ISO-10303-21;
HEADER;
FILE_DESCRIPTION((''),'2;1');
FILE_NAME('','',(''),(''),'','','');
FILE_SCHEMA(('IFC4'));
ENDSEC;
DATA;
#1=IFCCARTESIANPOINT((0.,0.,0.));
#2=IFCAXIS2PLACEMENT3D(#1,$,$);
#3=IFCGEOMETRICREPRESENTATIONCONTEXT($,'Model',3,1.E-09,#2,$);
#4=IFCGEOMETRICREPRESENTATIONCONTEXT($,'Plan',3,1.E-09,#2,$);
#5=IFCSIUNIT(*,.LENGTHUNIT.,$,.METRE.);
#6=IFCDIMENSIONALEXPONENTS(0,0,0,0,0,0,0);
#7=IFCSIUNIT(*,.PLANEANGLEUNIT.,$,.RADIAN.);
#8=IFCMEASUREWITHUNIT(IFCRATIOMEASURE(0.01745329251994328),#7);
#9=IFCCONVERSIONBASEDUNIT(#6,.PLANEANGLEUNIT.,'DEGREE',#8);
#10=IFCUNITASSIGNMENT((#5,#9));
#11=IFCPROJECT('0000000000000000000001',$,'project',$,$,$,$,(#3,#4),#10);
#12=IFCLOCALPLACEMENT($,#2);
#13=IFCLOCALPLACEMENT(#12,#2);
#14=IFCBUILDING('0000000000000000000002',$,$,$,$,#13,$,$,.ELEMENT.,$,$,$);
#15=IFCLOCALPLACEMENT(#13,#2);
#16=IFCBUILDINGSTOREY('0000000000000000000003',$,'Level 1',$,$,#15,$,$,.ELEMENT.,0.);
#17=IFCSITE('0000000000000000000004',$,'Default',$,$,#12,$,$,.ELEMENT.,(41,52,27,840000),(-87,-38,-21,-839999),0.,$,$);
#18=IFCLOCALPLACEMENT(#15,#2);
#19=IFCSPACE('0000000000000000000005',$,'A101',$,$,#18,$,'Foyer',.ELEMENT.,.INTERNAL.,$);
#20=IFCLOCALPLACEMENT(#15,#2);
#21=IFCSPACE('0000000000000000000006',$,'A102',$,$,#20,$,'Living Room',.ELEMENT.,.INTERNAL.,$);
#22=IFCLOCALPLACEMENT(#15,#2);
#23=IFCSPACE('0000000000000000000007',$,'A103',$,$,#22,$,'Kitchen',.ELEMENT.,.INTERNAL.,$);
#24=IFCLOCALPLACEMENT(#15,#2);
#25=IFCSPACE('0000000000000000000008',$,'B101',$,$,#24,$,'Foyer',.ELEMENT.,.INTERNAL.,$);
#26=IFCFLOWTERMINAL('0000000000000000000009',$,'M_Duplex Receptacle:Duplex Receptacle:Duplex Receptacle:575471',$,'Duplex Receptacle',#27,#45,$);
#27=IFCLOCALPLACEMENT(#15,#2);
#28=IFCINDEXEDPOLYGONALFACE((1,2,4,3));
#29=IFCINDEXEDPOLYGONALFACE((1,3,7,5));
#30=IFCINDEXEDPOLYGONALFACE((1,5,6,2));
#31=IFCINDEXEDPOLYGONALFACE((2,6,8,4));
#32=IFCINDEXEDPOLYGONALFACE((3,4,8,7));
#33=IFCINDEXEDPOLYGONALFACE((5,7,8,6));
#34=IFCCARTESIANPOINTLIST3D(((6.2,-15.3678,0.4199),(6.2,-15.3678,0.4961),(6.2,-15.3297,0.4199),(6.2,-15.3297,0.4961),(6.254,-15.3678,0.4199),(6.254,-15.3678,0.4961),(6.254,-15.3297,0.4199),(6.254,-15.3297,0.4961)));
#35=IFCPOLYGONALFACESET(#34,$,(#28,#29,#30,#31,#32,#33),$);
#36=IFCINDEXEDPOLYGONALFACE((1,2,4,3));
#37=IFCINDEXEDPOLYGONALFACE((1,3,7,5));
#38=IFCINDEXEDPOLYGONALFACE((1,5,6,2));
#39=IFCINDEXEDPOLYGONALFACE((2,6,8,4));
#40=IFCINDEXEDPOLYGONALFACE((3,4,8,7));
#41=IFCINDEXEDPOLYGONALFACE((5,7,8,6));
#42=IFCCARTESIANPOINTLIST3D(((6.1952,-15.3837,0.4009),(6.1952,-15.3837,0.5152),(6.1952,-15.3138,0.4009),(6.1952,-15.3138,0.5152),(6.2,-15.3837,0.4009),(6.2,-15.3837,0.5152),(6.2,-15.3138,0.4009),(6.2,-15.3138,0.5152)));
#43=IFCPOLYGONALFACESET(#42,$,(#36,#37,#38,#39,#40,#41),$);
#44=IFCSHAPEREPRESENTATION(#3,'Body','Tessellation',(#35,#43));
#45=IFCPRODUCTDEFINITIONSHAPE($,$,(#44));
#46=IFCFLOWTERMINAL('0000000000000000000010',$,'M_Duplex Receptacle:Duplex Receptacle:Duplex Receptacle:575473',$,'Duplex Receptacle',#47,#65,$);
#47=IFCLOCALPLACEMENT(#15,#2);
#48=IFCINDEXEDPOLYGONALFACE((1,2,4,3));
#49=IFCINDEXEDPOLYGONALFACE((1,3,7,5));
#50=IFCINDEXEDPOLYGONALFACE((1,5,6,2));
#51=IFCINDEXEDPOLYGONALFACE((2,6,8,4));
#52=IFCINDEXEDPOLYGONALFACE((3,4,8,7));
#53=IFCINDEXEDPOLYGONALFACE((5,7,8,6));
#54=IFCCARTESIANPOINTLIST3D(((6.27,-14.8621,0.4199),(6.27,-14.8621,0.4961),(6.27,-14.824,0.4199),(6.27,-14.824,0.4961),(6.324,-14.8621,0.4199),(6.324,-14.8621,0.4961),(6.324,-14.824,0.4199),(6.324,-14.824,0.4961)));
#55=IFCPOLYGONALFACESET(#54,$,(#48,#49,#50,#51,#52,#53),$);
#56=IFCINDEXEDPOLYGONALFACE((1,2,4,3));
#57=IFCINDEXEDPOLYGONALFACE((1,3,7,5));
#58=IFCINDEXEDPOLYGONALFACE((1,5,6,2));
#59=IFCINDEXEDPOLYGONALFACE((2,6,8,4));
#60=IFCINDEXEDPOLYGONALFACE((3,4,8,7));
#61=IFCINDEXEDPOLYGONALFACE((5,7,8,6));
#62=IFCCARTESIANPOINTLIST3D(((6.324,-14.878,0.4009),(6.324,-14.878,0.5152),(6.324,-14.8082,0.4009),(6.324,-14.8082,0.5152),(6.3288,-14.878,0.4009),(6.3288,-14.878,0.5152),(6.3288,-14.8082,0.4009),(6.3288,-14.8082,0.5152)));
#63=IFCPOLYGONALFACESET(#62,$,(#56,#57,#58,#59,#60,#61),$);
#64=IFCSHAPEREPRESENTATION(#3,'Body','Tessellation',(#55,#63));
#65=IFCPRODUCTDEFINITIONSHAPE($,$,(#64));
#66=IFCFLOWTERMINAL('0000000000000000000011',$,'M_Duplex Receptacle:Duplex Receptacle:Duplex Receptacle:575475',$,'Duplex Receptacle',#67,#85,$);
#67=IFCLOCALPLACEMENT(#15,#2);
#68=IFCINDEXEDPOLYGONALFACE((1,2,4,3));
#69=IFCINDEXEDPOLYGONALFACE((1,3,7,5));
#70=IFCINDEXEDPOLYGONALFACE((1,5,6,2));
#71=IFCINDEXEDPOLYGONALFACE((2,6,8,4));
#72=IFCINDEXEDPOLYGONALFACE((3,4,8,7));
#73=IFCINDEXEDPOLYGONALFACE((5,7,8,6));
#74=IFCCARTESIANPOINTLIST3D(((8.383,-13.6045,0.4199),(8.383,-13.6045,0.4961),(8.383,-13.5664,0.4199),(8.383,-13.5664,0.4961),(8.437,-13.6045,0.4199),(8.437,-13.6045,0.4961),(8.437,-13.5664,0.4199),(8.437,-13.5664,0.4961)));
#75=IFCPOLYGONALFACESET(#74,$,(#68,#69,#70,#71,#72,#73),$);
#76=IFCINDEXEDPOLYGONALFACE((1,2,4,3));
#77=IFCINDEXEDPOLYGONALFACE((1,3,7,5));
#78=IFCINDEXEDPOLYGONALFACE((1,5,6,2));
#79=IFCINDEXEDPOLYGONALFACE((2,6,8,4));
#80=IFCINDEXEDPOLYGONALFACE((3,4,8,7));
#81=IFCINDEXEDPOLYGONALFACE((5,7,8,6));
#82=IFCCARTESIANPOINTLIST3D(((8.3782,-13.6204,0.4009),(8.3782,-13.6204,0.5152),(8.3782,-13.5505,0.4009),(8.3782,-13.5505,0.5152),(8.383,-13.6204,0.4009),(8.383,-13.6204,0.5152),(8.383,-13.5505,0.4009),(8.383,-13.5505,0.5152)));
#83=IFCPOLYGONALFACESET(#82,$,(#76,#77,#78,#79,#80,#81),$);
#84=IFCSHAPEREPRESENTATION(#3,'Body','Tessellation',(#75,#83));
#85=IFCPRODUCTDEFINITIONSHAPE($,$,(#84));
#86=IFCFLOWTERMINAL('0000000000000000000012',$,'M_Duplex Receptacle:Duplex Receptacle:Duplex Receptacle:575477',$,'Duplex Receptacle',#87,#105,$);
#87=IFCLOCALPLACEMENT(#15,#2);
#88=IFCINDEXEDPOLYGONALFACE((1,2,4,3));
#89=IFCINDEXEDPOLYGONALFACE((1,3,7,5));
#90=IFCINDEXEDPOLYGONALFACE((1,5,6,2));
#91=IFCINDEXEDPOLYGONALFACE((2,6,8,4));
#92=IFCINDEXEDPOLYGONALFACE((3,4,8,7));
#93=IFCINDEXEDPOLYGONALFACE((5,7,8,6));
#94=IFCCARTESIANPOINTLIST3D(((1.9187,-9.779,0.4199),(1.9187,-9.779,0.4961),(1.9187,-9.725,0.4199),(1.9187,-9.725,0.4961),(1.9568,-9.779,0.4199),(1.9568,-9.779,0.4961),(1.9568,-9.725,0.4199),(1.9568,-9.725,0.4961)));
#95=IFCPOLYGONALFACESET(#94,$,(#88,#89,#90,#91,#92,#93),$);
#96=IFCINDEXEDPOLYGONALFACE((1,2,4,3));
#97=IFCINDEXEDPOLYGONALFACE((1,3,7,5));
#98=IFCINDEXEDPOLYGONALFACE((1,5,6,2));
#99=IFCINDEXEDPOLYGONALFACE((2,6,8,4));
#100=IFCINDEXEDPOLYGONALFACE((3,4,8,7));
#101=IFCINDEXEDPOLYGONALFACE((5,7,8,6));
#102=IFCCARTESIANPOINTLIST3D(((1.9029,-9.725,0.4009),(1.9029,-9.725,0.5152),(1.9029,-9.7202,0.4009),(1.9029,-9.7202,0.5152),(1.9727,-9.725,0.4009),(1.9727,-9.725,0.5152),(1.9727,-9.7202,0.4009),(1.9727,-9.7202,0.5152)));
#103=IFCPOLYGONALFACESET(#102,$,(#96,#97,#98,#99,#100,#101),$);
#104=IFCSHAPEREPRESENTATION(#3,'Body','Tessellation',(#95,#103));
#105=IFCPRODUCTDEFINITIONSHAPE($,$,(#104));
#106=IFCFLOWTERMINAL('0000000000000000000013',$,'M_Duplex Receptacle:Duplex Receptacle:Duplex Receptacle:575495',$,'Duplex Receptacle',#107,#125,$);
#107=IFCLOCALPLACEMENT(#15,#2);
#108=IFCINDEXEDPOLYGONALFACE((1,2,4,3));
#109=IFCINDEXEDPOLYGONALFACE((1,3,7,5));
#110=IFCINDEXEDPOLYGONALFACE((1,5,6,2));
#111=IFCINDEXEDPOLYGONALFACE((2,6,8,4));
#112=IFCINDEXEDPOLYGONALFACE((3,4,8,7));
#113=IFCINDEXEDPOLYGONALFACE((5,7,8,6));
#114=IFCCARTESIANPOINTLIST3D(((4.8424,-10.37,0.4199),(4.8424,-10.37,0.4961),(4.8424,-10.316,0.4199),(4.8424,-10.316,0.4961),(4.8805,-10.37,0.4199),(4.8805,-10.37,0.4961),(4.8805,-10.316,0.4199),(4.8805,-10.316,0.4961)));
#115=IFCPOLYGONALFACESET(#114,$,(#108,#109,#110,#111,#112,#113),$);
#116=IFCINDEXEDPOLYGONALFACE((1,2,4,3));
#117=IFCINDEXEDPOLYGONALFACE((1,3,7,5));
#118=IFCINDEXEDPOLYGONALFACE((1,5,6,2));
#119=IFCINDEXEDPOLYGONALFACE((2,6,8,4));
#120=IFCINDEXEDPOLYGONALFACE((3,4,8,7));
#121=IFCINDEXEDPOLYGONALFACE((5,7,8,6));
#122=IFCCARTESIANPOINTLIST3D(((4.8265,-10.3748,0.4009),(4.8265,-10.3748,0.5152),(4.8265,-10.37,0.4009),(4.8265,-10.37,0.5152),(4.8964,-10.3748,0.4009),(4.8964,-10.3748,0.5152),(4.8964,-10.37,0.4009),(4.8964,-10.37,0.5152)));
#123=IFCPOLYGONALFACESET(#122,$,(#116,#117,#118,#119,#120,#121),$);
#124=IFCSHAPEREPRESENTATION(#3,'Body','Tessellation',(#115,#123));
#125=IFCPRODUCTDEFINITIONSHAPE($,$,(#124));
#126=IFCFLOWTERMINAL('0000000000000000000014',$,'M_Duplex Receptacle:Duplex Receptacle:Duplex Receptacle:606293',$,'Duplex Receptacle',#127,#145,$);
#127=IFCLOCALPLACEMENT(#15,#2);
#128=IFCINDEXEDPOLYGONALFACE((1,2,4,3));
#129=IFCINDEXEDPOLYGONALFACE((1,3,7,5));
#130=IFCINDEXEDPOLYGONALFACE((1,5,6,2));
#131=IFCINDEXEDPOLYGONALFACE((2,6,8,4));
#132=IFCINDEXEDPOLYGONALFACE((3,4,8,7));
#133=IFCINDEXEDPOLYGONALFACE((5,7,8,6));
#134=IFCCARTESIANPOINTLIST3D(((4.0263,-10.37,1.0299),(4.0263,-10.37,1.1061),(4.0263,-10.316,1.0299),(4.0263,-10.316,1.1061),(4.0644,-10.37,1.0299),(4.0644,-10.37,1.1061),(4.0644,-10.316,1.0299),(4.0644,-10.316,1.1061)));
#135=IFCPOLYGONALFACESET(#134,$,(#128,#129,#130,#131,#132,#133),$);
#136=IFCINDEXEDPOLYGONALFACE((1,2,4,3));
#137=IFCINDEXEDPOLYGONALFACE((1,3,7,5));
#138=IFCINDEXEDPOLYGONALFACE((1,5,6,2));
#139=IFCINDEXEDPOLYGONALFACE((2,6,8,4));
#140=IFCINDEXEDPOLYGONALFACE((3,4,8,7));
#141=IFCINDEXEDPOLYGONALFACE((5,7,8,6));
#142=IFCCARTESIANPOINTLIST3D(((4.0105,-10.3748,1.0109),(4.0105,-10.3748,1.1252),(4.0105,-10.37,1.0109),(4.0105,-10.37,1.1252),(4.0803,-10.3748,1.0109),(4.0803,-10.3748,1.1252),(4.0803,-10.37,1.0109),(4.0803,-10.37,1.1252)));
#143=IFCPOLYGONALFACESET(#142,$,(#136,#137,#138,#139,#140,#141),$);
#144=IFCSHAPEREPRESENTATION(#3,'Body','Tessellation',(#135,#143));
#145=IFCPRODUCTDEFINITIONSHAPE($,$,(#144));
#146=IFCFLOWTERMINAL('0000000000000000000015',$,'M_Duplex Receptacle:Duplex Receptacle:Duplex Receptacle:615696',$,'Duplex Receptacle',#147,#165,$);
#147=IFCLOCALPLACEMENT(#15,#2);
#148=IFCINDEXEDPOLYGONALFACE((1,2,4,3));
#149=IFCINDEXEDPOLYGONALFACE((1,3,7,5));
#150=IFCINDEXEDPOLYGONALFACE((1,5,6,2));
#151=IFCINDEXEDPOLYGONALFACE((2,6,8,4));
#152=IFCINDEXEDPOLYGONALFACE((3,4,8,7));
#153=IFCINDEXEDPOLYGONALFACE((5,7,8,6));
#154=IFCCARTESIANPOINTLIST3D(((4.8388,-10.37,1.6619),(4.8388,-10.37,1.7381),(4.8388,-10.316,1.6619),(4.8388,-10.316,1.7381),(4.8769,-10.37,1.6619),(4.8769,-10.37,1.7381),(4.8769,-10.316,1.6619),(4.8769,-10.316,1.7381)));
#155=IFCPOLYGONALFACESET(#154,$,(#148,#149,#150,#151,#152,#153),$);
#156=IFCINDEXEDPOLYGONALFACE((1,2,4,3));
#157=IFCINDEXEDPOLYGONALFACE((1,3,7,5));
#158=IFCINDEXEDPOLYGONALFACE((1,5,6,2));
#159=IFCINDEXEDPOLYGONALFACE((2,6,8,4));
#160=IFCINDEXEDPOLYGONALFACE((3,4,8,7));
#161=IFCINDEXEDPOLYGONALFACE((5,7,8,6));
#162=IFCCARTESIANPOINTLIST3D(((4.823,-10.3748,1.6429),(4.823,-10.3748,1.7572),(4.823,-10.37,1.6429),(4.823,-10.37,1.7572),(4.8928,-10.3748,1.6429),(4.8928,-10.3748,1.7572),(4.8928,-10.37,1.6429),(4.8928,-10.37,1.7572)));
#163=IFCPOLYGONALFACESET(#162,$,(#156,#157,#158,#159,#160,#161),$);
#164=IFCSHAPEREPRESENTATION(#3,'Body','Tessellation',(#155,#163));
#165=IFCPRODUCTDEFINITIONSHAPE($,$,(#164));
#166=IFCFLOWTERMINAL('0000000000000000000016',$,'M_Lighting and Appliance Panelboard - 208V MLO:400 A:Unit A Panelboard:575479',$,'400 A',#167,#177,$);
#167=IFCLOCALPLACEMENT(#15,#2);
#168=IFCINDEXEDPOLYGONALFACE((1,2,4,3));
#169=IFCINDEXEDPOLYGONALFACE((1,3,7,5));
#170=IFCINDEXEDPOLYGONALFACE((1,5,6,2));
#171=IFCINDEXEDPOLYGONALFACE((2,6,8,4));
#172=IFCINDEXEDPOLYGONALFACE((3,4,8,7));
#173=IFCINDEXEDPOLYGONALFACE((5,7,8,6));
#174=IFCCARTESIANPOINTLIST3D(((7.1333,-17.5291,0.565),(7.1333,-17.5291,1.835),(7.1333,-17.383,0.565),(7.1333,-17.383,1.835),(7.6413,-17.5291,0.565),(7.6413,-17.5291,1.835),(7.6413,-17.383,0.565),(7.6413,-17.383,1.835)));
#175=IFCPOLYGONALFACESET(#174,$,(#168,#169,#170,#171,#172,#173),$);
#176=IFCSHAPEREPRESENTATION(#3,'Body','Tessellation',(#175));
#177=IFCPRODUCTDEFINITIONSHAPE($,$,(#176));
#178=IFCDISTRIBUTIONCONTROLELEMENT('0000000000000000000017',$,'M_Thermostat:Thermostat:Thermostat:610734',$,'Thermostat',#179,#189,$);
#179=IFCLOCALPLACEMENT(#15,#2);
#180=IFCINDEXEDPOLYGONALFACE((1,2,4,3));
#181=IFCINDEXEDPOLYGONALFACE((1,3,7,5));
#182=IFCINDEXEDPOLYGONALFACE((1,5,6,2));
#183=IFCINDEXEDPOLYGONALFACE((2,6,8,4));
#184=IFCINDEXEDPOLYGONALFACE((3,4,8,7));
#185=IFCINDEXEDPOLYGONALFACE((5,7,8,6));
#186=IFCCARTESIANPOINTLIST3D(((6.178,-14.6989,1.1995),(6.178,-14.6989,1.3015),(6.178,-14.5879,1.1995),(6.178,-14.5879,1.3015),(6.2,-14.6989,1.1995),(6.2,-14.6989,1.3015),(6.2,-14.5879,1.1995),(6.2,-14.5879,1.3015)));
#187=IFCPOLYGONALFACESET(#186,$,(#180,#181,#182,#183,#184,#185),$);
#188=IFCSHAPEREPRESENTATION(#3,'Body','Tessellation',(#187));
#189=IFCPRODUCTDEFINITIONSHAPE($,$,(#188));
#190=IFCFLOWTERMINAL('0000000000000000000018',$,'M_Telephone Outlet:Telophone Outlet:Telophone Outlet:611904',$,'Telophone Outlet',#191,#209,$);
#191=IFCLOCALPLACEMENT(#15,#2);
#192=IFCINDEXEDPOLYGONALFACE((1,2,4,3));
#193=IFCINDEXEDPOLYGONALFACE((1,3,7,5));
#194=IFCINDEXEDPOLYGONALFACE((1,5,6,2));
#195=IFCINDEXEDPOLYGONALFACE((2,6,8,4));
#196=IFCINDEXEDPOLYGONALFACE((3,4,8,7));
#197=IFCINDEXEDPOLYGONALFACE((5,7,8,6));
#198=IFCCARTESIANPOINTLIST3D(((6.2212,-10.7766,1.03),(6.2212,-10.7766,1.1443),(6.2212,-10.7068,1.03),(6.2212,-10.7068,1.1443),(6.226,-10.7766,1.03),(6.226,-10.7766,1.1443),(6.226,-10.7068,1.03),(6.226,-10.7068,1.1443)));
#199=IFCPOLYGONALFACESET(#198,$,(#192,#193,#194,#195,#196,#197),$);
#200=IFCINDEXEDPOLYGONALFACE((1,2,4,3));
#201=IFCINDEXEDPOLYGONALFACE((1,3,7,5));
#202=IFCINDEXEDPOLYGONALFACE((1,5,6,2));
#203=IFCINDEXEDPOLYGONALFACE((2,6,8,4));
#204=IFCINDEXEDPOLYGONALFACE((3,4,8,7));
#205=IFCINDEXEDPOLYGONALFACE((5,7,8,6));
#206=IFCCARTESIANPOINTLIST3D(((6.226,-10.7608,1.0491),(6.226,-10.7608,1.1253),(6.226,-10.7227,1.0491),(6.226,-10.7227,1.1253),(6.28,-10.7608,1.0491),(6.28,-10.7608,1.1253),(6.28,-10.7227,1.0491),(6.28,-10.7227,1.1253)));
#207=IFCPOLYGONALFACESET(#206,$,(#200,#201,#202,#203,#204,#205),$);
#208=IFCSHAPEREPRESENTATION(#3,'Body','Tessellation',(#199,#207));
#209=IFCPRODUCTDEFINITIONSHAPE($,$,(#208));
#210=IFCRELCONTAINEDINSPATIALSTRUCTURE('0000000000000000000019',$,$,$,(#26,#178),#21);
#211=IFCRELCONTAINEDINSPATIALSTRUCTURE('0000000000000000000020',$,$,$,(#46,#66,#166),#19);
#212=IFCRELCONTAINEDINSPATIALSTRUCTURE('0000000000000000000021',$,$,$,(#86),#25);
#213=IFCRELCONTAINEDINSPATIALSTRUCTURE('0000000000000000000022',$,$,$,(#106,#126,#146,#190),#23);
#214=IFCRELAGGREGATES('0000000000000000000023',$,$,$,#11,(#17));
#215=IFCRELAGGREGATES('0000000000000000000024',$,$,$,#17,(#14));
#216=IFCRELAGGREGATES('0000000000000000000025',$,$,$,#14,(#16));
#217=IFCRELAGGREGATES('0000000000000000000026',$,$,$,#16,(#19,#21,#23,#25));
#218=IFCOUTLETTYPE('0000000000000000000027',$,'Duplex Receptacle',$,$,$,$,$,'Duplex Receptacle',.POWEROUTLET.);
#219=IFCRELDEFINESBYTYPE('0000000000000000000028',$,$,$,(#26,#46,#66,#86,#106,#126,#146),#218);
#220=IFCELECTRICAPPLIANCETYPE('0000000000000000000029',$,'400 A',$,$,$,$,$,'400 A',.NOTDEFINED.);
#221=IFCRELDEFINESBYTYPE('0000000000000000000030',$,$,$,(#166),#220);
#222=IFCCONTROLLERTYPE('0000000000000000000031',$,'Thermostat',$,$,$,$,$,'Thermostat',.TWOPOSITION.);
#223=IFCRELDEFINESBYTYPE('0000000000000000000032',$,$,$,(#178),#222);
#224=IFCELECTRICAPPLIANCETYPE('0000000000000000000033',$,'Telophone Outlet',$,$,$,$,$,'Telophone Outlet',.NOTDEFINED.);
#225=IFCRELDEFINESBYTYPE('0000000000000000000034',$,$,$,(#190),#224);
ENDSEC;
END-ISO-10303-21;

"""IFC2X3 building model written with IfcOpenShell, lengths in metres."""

from ifc_helpers import new_model, entity, si_unit, converted_unit, frame, origin, origin_2d_with_axis, place, context, project, spatial, rectangle, extrude, source, transform, mapped, type_object, type_shapes, element, save


model = new_model("IFC2X3")

# Units and contexts
model_context = context("Model", 3, precision=1e-09, world=origin())
plan_context = context("Plan", 3, precision=1e-09, world=origin())
ifc_project = project(units=[si_unit("LENGTHUNIT", "METRE"), converted_unit("PLANEANGLEUNIT", "DEGREE", entity("IfcRatioMeasure", 0.01745329251994328), si_unit("PLANEANGLEUNIT", "RADIAN"), dimensions=[0, 0, 0, 0, 0, 0, 0])], contexts=[model_context, plan_context])

# Site, building, storey, space
site_placement = place(None, origin())
site = spatial("IfcSite", under=ifc_project, at=site_placement, Name="Default", CompositionType="ELEMENT", RefLatitude=(41, 52, 27, 840000), RefLongitude=(-87, -38, -21, -839999), RefElevation=0.0)
building_placement = place(site_placement, origin())
building = spatial("IfcBuilding", under=site, at=building_placement, CompositionType="ELEMENT")
storey_placement = place(building_placement, origin())
storey = spatial("IfcBuildingStorey", under=building, at=storey_placement, Name="Level 1", CompositionType="ELEMENT", Elevation=0.0)
space_1_placement = place(storey_placement, origin())
space_1 = spatial("IfcSpace", under=storey, at=space_1_placement, Name="A101", LongName="Foyer", CompositionType="ELEMENT", InteriorOrExteriorSpace="INTERNAL")

# Shared definitions
space_2_placement = place(storey_placement, origin())
space_2 = spatial("IfcSpace", under=storey, at=space_2_placement, Name="A102", LongName="Living Room", CompositionType="ELEMENT", InteriorOrExteriorSpace="INTERNAL")

# Shared definitions
outlet_type = type_object("IfcOutletType", Name="Duplex Receptacle", ElementType="Duplex Receptacle", PredefinedType="POWEROUTLET")
shared_shape_1 = source(origin(), model_context, "Body", "SweptSolid", [
    extrude(rectangle(XDim=0.0381, YDim=0.0762, at=origin_2d_with_axis()), frame((0.0, 0.0, -0.054), z_axis=(0.0, 0.0, 1.0), x_axis=(-1.0, 0.0, 0.0)), (0.0, 0.0, 1.0), 0.054),
    extrude(rectangle(XDim=0.0698, YDim=0.1143, at=origin_2d_with_axis()), frame((0.0, 0.0, 0.0), z_axis=(0.0, 0.0, 1.0), x_axis=(-1.0, 0.0, 0.0)), (0.0, 0.0, 1.0), 0.0048),
])
type_shapes(outlet_type, [shared_shape_1])

# Shared definitions
space_3_placement = place(storey_placement, origin())
space_3 = spatial("IfcSpace", under=storey, at=space_3_placement, Name="A103", LongName="Kitchen", CompositionType="ELEMENT", InteriorOrExteriorSpace="INTERNAL")

# Flow terminals
for number, where, z_axis, x_axis, name in (
    (1, (6.2, -15.3487, 0.458), (-1.0, 0.0, 0.0), (0.0, -1.0, 0.0), "M_Duplex Receptacle:Duplex Receptacle:Duplex Receptacle:575471"),
):
    element("IfcFlowTerminal", number, at=place(space_2_placement, frame(where, z_axis=z_axis, x_axis=x_axis)), inside=space_2, type_object=outlet_type, Name=name, ObjectType="Duplex Receptacle", context=model_context, shape_type="MappedRepresentation", body=[
        mapped(shared_shape_1, transform((0.0, 0.0, 0.0), scale=1.0)),
    ])
for number, where, z_axis, x_axis, name in (
    (2, (6.324, -14.8431, 0.458), (1.0, 0.0, 0.0), (0.0, 1.0, 0.0), "M_Duplex Receptacle:Duplex Receptacle:Duplex Receptacle:575473"),
    (3, (8.383, -13.5854, 0.458), (-1.0, 0.0, 0.0), (0.0, -1.0, 0.0), "M_Duplex Receptacle:Duplex Receptacle:Duplex Receptacle:575475"),
):
    element("IfcFlowTerminal", number, at=place(space_1_placement, frame(where, z_axis=z_axis, x_axis=x_axis)), inside=space_1, type_object=outlet_type, Name=name, ObjectType="Duplex Receptacle", context=model_context, shape_type="MappedRepresentation", body=[
        mapped(shared_shape_1, transform((0.0, 0.0, 0.0), scale=1.0)),
    ])

# Shared definitions
space_4_placement = place(storey_placement, origin())
space_4 = spatial("IfcSpace", under=storey, at=space_4_placement, Name="B101", LongName="Foyer", CompositionType="ELEMENT", InteriorOrExteriorSpace="INTERNAL")

# Flow terminals
flow_terminal_1_placement = place(space_4_placement, frame((1.9378, -9.725, 0.458), z_axis=(0.0, 1.0, 0.0), x_axis=(-1.0, 0.0, 0.0)))
element("IfcFlowTerminal", 4, at=flow_terminal_1_placement, inside=space_4, type_object=outlet_type, Name="M_Duplex Receptacle:Duplex Receptacle:Duplex Receptacle:575477", ObjectType="Duplex Receptacle", context=model_context, shape_type="MappedRepresentation", body=[
    mapped(shared_shape_1, transform((0.0, 0.0, 0.0), scale=1.0)),
])
for number, where, z_axis, x_axis, name in (
    (5, (4.8615, -10.37, 0.458), (0.0, -1.0, 0.0), (1.0, 0.0, 0.0), "M_Duplex Receptacle:Duplex Receptacle:Duplex Receptacle:575495"),
    (6, (4.0454, -10.37, 1.068), (0.0, -1.0, 0.0), (1.0, 0.0, 0.0), "M_Duplex Receptacle:Duplex Receptacle:Duplex Receptacle:606293"),
    (7, (4.8579, -10.37, 1.7), (0.0, -1.0, 0.0), (1.0, 0.0, 0.0), "M_Duplex Receptacle:Duplex Receptacle:Duplex Receptacle:615696"),
):
    element("IfcFlowTerminal", number, at=place(space_3_placement, frame(where, z_axis=z_axis, x_axis=x_axis)), inside=space_3, type_object=outlet_type, Name=name, ObjectType="Duplex Receptacle", context=model_context, shape_type="MappedRepresentation", body=[
        mapped(shared_shape_1, transform((0.0, 0.0, 0.0), scale=1.0)),
    ])
electric_appliance_type_1 = type_object("IfcElectricApplianceType", Name="400 A", ElementType="400 A", PredefinedType="NOTDEFINED")
shared_shape_2 = source(origin(), model_context, "Body", "SweptSolid", [
    extrude(rectangle(XDim=0.508, YDim=1.27, at=origin_2d_with_axis()), frame((0.0, -0.4191, -0.1461), z_axis=(0.0, 0.0, 1.0), x_axis=(-1.0, 0.0, 0.0)), (0.0, 0.0, 1.0), 0.1461),
])
type_shapes(electric_appliance_type_1, [shared_shape_2])
flow_terminal_2_placement = place(space_1_placement, frame((7.3873, -17.383, 1.6191), z_axis=(0.0, 1.0, 0.0), x_axis=(-1.0, 0.0, 0.0)))
element("IfcFlowTerminal", 8, at=flow_terminal_2_placement, inside=space_1, type_object=electric_appliance_type_1, Name="M_Lighting and Appliance Panelboard - 208V MLO:400 A:Unit A Panelboard:575479", ObjectType="400 A", context=model_context, shape_type="MappedRepresentation", body=[
    mapped(shared_shape_2, transform((0.0, 0.0, 0.0), scale=1.0)),
])

# Distribution control element
controller_type = type_object("IfcControllerType", Name="Thermostat", ElementType="Thermostat", PredefinedType="TWOPOSITION")
shared_shape_3 = source(origin(), model_context, "Body", "SweptSolid", [
    extrude(rectangle(XDim=0.102, YDim=0.111, at=origin_2d_with_axis()), frame((0.0, -0.051, 0.0), z_axis=(0.0, 0.0, 1.0), x_axis=(0.0, 1.0, 0.0)), (0.0, 0.0, 1.0), 0.022),
])
type_shapes(controller_type, [shared_shape_3])
distribution_control_element_placement = place(space_2_placement, frame((6.2, -14.6434, 1.3015), z_axis=(-1.0, 0.0, 0.0), x_axis=(0.0, -1.0, 0.0)))
element("IfcDistributionControlElement", 9, at=distribution_control_element_placement, inside=space_2, type_object=controller_type, Name="M_Thermostat:Thermostat:Thermostat:610734", ObjectType="Thermostat", context=model_context, shape_type="MappedRepresentation", body=[
    mapped(shared_shape_3, transform((0.0, 0.0, 0.0), scale=1.0)),
])

# Flow terminal
electric_appliance_type_2 = type_object("IfcElectricApplianceType", Name="Telophone Outlet", ElementType="Telophone Outlet", PredefinedType="NOTDEFINED")
shared_shape_4 = source(origin(), model_context, "Body", "SweptSolid", [
    extrude(rectangle(XDim=0.0699, YDim=0.1143, at=origin_2d_with_axis()), frame((0.0, 0.0, 0.0), z_axis=(0.0, 0.0, 1.0), x_axis=(-1.0, 0.0, 0.0)), (0.0, 0.0, 1.0), 0.0048),
    extrude(rectangle(XDim=0.0381, YDim=0.0762, at=origin_2d_with_axis()), frame((0.0, 0.0, -0.054), z_axis=(0.0, 0.0, 1.0), x_axis=(-1.0, 0.0, 0.0)), (0.0, 0.0, 1.0), 0.054),
])
type_shapes(electric_appliance_type_2, [shared_shape_4])
flow_terminal_3_placement = place(space_3_placement, frame((6.226, -10.7417, 1.0872), z_axis=(-1.0, 0.0, 0.0), x_axis=(0.0, -1.0, 0.0)))
element("IfcFlowTerminal", 10, at=flow_terminal_3_placement, inside=space_3, type_object=electric_appliance_type_2, Name="M_Telephone Outlet:Telophone Outlet:Telophone Outlet:611904", ObjectType="Telophone Outlet", context=model_context, shape_type="MappedRepresentation", body=[
    mapped(shared_shape_4, transform((0.0, 0.0, 0.0), scale=1.0)),
])

save(model, "model.ifc")
